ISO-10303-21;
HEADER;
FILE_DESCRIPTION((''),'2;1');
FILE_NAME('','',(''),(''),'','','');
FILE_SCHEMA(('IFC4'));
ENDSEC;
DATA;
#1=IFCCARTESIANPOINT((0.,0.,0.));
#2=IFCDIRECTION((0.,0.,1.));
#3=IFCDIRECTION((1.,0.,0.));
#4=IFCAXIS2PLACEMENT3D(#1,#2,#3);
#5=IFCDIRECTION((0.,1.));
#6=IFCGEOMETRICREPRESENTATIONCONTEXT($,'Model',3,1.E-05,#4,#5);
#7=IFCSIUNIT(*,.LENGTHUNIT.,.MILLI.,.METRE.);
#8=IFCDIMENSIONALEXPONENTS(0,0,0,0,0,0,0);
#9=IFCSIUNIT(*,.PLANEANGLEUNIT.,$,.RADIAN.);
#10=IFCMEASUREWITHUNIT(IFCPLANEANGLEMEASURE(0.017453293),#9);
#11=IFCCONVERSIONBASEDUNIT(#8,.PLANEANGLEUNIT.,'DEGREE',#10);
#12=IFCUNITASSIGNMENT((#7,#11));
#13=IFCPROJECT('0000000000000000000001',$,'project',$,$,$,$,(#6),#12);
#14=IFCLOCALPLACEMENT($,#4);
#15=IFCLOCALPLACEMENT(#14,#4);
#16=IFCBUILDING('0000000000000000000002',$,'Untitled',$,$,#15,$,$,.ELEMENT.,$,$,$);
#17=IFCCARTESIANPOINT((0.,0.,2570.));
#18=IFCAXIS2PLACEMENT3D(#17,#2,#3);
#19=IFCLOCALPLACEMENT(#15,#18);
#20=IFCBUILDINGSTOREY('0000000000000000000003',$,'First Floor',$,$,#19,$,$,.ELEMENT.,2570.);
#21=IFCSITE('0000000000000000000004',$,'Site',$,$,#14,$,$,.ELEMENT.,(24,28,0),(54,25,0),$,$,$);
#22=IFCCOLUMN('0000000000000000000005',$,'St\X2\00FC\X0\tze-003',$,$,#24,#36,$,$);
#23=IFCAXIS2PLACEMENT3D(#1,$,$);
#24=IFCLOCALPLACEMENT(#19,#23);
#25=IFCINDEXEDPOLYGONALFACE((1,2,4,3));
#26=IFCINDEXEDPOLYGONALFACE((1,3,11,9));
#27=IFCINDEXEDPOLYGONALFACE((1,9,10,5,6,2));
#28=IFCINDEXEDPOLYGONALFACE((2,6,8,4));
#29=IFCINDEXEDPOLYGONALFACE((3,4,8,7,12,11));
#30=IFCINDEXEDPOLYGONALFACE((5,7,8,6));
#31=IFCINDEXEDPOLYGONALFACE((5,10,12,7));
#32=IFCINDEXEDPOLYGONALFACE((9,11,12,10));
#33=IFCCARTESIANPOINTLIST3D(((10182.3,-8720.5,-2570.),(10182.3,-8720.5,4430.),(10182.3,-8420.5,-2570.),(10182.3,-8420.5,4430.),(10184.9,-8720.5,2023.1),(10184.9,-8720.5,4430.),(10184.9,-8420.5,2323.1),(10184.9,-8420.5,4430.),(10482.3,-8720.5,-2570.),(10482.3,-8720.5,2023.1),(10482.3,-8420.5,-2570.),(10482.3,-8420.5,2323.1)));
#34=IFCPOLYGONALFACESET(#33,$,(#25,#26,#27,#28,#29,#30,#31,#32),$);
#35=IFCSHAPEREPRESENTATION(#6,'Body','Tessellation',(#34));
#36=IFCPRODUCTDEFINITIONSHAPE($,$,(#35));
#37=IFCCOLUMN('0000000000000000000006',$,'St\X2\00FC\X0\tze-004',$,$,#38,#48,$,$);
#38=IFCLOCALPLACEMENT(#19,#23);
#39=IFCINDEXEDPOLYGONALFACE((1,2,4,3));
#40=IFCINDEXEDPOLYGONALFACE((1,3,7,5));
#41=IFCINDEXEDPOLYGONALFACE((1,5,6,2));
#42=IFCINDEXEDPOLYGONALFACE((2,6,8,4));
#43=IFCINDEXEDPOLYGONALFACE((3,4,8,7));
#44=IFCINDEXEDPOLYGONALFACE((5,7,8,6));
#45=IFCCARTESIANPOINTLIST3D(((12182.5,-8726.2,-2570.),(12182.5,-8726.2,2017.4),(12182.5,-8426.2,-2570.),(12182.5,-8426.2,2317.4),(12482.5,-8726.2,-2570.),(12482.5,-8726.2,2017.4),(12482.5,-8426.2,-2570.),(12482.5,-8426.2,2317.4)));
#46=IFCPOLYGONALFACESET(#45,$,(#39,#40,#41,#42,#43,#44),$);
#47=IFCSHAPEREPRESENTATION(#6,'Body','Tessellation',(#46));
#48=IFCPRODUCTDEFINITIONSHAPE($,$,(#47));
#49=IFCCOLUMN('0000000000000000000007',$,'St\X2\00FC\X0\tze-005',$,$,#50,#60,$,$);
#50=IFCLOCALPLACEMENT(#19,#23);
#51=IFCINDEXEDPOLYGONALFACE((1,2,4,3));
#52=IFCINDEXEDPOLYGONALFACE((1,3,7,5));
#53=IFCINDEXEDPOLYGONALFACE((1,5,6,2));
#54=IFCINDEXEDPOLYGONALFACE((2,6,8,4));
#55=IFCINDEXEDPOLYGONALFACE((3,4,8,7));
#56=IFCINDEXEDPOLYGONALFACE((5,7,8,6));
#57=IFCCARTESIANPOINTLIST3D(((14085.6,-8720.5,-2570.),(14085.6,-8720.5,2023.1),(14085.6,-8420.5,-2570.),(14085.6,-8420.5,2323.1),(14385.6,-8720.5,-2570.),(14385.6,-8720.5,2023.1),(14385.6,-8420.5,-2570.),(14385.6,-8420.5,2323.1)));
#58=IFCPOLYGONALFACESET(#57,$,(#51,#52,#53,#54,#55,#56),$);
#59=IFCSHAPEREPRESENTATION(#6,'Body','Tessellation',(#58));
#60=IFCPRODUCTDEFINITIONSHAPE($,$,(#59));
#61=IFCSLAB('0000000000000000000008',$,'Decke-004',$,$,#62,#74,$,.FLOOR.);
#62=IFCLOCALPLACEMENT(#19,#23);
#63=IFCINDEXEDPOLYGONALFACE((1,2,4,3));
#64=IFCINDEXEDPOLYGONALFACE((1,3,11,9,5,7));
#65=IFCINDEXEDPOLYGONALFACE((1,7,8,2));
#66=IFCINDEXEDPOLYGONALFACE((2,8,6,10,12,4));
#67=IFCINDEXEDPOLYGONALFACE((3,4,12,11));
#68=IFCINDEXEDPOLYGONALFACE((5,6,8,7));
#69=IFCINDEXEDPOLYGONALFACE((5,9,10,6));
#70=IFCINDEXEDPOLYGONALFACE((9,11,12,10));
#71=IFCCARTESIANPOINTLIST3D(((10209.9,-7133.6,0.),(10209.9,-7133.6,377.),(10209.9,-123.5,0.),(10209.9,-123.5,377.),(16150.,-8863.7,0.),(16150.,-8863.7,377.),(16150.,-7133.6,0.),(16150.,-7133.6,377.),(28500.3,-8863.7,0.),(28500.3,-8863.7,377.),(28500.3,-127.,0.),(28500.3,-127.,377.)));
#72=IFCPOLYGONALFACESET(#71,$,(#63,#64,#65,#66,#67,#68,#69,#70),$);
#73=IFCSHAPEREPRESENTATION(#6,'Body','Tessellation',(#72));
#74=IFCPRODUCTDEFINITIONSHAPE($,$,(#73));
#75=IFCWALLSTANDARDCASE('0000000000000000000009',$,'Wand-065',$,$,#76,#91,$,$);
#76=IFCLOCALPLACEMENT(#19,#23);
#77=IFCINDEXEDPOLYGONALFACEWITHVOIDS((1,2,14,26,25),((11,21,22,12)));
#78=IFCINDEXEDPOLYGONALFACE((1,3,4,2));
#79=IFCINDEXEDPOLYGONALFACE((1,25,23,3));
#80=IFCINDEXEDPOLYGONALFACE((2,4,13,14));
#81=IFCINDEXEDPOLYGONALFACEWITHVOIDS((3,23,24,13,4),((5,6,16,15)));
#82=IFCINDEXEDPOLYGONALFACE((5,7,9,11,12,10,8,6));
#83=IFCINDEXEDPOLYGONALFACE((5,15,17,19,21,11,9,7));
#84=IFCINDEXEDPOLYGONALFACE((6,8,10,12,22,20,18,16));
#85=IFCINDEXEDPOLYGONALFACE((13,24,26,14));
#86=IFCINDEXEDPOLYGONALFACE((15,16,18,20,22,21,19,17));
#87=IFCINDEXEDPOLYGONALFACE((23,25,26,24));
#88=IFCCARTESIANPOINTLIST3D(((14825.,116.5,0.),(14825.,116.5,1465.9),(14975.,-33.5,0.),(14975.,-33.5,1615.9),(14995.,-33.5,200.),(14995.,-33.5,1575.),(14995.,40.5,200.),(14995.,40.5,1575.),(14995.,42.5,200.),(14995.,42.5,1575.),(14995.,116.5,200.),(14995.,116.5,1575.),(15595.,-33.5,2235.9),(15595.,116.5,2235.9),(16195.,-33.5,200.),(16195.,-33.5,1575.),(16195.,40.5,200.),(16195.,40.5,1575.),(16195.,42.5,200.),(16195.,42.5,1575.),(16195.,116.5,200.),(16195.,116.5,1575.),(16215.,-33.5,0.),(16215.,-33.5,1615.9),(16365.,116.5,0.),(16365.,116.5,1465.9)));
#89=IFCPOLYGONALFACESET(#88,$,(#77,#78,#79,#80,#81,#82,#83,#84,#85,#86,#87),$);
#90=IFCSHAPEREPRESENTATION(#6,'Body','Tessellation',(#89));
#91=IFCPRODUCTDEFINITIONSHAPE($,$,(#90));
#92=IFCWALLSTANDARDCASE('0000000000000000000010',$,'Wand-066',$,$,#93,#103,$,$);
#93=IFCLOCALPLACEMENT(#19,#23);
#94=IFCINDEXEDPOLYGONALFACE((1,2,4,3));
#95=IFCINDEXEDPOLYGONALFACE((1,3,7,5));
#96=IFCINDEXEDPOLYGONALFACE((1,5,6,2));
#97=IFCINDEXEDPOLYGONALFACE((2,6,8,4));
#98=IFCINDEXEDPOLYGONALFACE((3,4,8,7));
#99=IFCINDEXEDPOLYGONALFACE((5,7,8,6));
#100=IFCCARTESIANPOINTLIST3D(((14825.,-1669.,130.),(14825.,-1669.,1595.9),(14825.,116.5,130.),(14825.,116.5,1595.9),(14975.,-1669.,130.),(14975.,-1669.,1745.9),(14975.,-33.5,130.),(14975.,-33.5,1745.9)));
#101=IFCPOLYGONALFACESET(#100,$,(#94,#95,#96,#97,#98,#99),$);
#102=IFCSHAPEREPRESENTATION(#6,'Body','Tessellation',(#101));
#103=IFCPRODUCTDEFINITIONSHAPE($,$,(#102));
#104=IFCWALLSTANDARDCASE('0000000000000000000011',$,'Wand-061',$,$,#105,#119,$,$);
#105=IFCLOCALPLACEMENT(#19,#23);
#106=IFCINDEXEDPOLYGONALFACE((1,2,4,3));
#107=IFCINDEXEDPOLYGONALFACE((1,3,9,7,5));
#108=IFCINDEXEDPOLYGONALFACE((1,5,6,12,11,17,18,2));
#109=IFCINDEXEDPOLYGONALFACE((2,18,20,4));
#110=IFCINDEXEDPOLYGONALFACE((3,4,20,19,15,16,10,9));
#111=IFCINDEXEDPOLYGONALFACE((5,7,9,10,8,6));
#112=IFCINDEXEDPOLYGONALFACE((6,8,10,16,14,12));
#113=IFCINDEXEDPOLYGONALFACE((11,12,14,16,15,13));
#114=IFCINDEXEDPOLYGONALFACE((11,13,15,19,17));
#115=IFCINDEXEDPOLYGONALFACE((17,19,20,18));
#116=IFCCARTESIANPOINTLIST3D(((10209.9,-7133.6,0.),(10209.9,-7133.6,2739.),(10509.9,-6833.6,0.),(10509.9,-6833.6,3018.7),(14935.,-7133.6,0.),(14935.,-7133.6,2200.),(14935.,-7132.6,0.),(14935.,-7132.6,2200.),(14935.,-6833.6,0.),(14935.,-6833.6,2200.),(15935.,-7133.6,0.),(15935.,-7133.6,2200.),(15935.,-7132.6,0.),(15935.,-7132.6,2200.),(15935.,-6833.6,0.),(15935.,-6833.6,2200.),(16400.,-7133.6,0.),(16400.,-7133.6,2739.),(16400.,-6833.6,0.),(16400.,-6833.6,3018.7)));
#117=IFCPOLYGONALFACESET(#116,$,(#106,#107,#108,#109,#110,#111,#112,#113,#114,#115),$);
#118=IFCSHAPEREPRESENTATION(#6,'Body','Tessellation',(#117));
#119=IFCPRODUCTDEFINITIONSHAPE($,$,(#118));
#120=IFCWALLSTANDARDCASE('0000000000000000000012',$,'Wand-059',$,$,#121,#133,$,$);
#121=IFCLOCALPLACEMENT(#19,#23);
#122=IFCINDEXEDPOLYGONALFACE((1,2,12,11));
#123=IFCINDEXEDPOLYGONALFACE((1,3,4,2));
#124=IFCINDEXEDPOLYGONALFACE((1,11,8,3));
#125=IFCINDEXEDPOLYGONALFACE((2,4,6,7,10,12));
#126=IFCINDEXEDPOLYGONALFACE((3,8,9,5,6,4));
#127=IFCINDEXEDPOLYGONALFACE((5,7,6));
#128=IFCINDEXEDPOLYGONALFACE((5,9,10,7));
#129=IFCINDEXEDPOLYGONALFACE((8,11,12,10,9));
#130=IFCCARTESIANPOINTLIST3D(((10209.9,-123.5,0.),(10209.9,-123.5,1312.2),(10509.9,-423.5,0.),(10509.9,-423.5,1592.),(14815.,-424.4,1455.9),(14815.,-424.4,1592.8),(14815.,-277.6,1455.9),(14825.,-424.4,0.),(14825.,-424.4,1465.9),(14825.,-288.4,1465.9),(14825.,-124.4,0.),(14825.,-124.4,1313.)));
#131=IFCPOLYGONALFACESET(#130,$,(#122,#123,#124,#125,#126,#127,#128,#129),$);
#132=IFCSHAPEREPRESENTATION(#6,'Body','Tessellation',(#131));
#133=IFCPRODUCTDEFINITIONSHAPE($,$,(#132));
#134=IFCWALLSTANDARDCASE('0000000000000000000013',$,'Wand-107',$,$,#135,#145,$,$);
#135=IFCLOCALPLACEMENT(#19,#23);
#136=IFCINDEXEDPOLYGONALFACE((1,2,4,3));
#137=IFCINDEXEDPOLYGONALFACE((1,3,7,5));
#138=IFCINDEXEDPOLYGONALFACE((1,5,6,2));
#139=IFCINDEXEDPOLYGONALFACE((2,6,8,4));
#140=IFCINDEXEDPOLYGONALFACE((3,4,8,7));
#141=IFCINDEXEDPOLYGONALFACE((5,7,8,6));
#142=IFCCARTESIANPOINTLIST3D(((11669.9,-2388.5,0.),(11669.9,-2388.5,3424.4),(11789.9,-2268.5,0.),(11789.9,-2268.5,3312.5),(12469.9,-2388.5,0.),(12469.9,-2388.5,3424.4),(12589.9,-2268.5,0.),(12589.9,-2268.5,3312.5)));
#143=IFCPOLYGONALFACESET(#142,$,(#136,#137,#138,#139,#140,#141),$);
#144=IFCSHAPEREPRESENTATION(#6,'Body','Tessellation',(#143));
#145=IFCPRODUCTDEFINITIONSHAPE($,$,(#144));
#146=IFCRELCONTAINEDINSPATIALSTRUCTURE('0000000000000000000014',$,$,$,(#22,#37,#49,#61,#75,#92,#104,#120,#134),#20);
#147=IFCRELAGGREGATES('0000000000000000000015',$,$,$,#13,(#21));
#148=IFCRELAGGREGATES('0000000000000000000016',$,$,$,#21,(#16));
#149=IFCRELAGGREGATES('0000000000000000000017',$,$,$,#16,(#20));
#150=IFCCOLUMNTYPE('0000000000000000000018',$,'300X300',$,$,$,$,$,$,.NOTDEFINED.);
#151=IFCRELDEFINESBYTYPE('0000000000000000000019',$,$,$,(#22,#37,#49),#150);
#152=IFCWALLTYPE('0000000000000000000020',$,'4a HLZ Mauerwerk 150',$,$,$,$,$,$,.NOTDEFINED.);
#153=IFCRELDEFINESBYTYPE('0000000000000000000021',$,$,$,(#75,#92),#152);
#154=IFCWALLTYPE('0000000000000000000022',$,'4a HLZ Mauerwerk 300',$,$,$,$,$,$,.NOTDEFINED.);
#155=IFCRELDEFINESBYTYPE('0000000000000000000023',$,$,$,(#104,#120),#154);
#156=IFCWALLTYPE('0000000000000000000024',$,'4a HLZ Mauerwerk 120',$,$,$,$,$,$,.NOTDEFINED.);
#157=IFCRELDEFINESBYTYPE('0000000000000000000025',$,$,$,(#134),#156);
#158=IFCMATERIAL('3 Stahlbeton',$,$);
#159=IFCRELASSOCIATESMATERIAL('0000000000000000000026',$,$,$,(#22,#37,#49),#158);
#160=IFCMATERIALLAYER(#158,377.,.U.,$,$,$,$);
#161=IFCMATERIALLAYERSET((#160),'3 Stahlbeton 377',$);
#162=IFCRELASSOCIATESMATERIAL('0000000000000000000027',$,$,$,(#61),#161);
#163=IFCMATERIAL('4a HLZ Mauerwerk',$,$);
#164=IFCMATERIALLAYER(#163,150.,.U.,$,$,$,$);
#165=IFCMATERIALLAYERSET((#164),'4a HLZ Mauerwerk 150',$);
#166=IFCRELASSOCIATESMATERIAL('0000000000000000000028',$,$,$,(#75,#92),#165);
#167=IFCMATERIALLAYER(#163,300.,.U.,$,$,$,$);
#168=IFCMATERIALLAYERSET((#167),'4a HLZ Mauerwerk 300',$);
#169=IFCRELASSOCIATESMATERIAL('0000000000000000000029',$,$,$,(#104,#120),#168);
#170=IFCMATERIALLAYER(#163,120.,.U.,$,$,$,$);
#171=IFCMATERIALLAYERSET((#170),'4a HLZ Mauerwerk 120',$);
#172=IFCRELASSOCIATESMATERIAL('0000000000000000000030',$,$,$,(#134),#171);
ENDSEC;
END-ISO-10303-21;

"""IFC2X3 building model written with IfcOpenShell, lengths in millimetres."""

from ifc_helpers import new_model, entity, si_unit, converted_unit, direction, frame, origin_with_axes, origin_2d_with_axis, place, context, project, spatial, polyline, rectangle, outline, extrude, clip, halfspace, bounded_halfspace, material, layer, layer_set, layer_usage, type_object, element, save


model = new_model("IFC2X3")

# Units and contexts
model_context = context("Model", 3, precision=1e-05, world=origin_with_axes(), true_north=direction((0.0, 1.0)))
ifc_project = project(units=[si_unit("LENGTHUNIT", "METRE", prefix="MILLI"), converted_unit("PLANEANGLEUNIT", "DEGREE", entity("IfcPlaneAngleMeasure", 0.017453293), si_unit("PLANEANGLEUNIT", "RADIAN"), dimensions=[0, 0, 0, 0, 0, 0, 0])], contexts=[model_context])

# Site, building, storey
site_placement = place(None, origin_with_axes())
site = spatial("IfcSite", under=ifc_project, at=site_placement, Name="Site", CompositionType="ELEMENT", RefLatitude=(24, 28, 0), RefLongitude=(54, 25, 0))
building_placement = place(site_placement, origin_with_axes())
building = spatial("IfcBuilding", under=site, at=building_placement, Name="Untitled", CompositionType="ELEMENT")
storey_placement = place(building_placement, frame((0.0, 0.0, 2570.0), z_axis=(0.0, 0.0, 1.0), x_axis=(1.0, 0.0, 0.0)))
storey = spatial("IfcBuildingStorey", under=building, at=storey_placement, Name="First Floor", CompositionType="ELEMENT", Elevation=2570.0)

# Columns
ifc_material_1 = material(Name="3 Stahlbeton")
column_type = type_object("IfcColumnType", Name="300X300", PredefinedType="NOTDEFINED")
column_1_placement = place(storey_placement, frame((10332.3, -8570.5, -2570.0), z_axis=(0.0, 0.0, 1.0), x_axis=(1.0, 0.0, 0.0)))
element("IfcColumn", 1, at=column_1_placement, inside=storey, type_object=column_type, material=ifc_material_1, Name="Stütze-003", context=model_context, shape_type="Clipping", body=[
    clip(extrude(rectangle(XDim=300.0, YDim=300.0, at=origin_2d_with_axis()), origin_with_axes(), (0.0, 0.0, 1.0), 7000.0), bounded_halfspace(frame((0.0, -2371.6, 2371.6), z_axis=(0.0, 0.707107, -0.707107), x_axis=(0.0, -0.707107, -0.707107)), True, origin_with_axes(), polyline([(-147.5, -150.0), (150.0, -150.0), (150.0, 150.0), (-147.5, 150.0), (-147.5, -150.0)]))),
])
column_2_placement = place(storey_placement, frame((12332.5, -8576.2, -2570.0), z_axis=(0.0, 0.0, 1.0), x_axis=(1.0, 0.0, 0.0)))
element("IfcColumn", 2, at=column_2_placement, inside=storey, type_object=column_type, material=ifc_material_1, Name="Stütze-004", context=model_context, shape_type="Clipping", body=[
    clip(extrude(rectangle(XDim=300.0, YDim=300.0, at=origin_2d_with_axis()), origin_with_axes(), (0.0, 0.0, 1.0), 7000.0), halfspace(frame((0.0, -2368.7, 2368.7), z_axis=(0.0, 0.707107, -0.707107), x_axis=(0.0, -0.707107, -0.707107)), True)),
])
column_3_placement = place(storey_placement, frame((14235.6, -8570.5, -2570.0), z_axis=(0.0, 0.0, 1.0), x_axis=(1.0, 0.0, 0.0)))
element("IfcColumn", 3, at=column_3_placement, inside=storey, type_object=column_type, material=ifc_material_1, Name="Stütze-005", context=model_context, shape_type="Clipping", body=[
    clip(extrude(rectangle(XDim=300.0, YDim=300.0, at=origin_2d_with_axis()), origin_with_axes(), (0.0, 0.0, 1.0), 7000.0), halfspace(frame((0.0, -2371.6, 2371.6), z_axis=(0.0, 0.707107, -0.707107), x_axis=(0.0, -0.707107, -0.707107)), True)),
])

# Slab
ifc_layer_1 = layer(ifc_material_1, 377.0, ventilated="UNKNOWN")
ifc_layer_set_1 = layer_set([ifc_layer_1], Name="3 Stahlbeton 377")
ifc_layer_usage_1 = layer_usage(ifc_layer_set_1, "AXIS3", "NEGATIVE", 377.0)
slab_placement = place(storey_placement, frame((10209.9, -123.5, 0.0), z_axis=(0.0, 0.0, 1.0), x_axis=(1.0, 0.0, 0.0)))
element("IfcSlab", 4, at=slab_placement, inside=storey, material=ifc_layer_usage_1, Name="Decke-004", PredefinedType="FLOOR", context=model_context, shape_type="SweptSolid", body=[
    extrude(outline(polyline([(0.0, 0.0), (0.0, -7010.2), (5940.1, -7010.2), (5940.1, -8740.2), (18290.4, -8740.2), (18290.4, -3.5), (0.0, 0.0)])), origin_with_axes(), (0.0, 0.0, 1.0), 377.0),
])

# Wall, opening
ifc_material_2 = material(Name="4a HLZ Mauerwerk")
ifc_layer_2 = layer(ifc_material_2, 150.0, ventilated="UNKNOWN")
ifc_layer_set_2 = layer_set([ifc_layer_2], Name="4a HLZ Mauerwerk 150")
ifc_layer_usage_2 = layer_usage(ifc_layer_set_2, "AXIS2", "NEGATIVE", 0.0)
wall_type_1 = type_object("IfcWallType", Name="4a HLZ Mauerwerk 150", PredefinedType="NOTDEFINED")
wall_1_placement = place(storey_placement, frame((14825.0, 116.5, 0.0), z_axis=(0.0, 0.0, 1.0), x_axis=(1.0, 0.0, 0.0)))
wall_1 = element("IfcWallStandardCase", 5, at=wall_1_placement, inside=storey, type_object=wall_type_1, material=ifc_layer_usage_2, Name="Wand-065", context=model_context, shape_type="Clipping", body=[
    clip(clip(extrude(outline(polyline([(150.0, -150.0), (1390.0, -150.0), (1540.0, 0.0), (0.0, 0.0), (150.0, -150.0)])), origin_with_axes(), (0.0, 0.0, 1.0), 5316.0), bounded_halfspace(frame((1503.0, 0.0, 1503.0), z_axis=(-0.707107, 0.0, -0.707107), x_axis=(0.707107, 0.0, -0.707107)), True, origin_with_axes(), polyline([(770.0, -150.0), (1540.0, -150.0), (1540.0, 0.0), (770.0, 0.0), (770.0, -150.0)]))), bounded_halfspace(frame((-733.0, 0.0, 733.0), z_axis=(0.707107, 0.0, -0.707107), x_axis=(0.707107, 0.0, 0.707107)), True, origin_with_axes(), polyline([(0.0, -150.0), (770.0, -150.0), (770.0, 0.0), (0.0, 0.0), (0.0, -150.0)]))),
])
opening_1_placement = place(wall_1_placement, frame((770.0, 0.0, 200.0), z_axis=(0.0, 0.0, 1.0), x_axis=(1.0, 0.0, 0.0)))
element("IfcOpeningElement", 6, at=opening_1_placement, cuts=wall_1, context=model_context, shape_type="SweptSolid", body=[
    extrude(rectangle(XDim=1200.0, YDim=1375.0, at=origin_2d_with_axis()), frame((0.0, 226.0, 687.5), z_axis=(0.0, -1.0, 0.0), x_axis=(1.0, 0.0, 0.0)), (0.0, 0.0, 1.0), 302.0),
    extrude(rectangle(XDim=1200.0, YDim=1375.0, at=origin_2d_with_axis()), frame((0.0, -376.0, 687.5), z_axis=(0.0, 1.0, 0.0), x_axis=(1.0, 0.0, 0.0)), (0.0, 0.0, 1.0), 302.0),
])

# Wall
ifc_layer_usage_3 = layer_usage(ifc_layer_set_2, "AXIS2", "POSITIVE", 0.0)
wall_2_placement = place(storey_placement, frame((14825.0, 116.5, 130.0), z_axis=(0.0, 0.0, 1.0), x_axis=(0.0, -1.0, 0.0)))
element("IfcWallStandardCase", 7, at=wall_2_placement, inside=storey, type_object=wall_type_1, material=ifc_layer_usage_3, Name="Wand-066", context=model_context, shape_type="Clipping", body=[
    clip(extrude(outline(polyline([(0.0, 0.0), (1785.6, 0.0), (1785.6, 150.0), (150.0, 150.0), (0.0, 0.0)])), origin_with_axes(), (0.0, 0.0, 1.0), 5186.0), halfspace(frame((0.0, -733.0, 733.0), z_axis=(0.0, 0.707107, -0.707107), x_axis=(0.0, -0.707107, -0.707107)), True)),
])

# Shared definitions
ifc_layer_3 = layer(ifc_material_2, 300.0, ventilated="UNKNOWN")
ifc_layer_set_3 = layer_set([ifc_layer_3], Name="4a HLZ Mauerwerk 300")
wall_type_2 = type_object("IfcWallType", Name="4a HLZ Mauerwerk 300", PredefinedType="NOTDEFINED")

# Wall, opening
ifc_layer_usage_4 = layer_usage(ifc_layer_set_3, "AXIS2", "POSITIVE", 0.0)
wall_3_placement = place(storey_placement, frame((10209.9, -7133.6, 0.0), z_axis=(0.0, 0.0, 1.0), x_axis=(1.0, 0.0, 0.0)))
wall_3 = element("IfcWallStandardCase", 8, at=wall_3_placement, inside=storey, type_object=wall_type_2, material=ifc_layer_usage_4, Name="Wand-061", context=model_context, shape_type="Clipping", body=[
    clip(extrude(outline(polyline([(0.0, 0.0), (6190.1, 0.0), (6190.1, 300.0), (300.0, 300.0), (0.0, 0.0)])), origin_with_axes(), (0.0, 0.0, 1.0), 5316.0), bounded_halfspace(frame((0.0, -1366.1, 1465.0), z_axis=(0.0, 0.681998, -0.731354), x_axis=(0.0, -0.731354, -0.681998)), True, origin_with_axes(), polyline([(0.0, 0.0), (6190.1, 0.0), (6190.1, 300.0), (0.0, 300.0), (0.0, 0.0)]))),
])
opening_2_placement = place(wall_3_placement, frame((5225.1, 0.0, 0.0), z_axis=(0.0, 0.0, 1.0), x_axis=(1.0, 0.0, 0.0)))
element("IfcOpeningElement", 9, at=opening_2_placement, cuts=wall_3, context=model_context, shape_type="SweptSolid", body=[
    extrude(rectangle(XDim=1000.0, YDim=2200.0, at=origin_2d_with_axis()), frame((0.0, -601.0, 1100.0), z_axis=(0.0, 1.0, 0.0), x_axis=(1.0, 0.0, 0.0)), (0.0, 0.0, 1.0), 602.0),
    extrude(rectangle(XDim=1000.0, YDim=2200.0, at=origin_2d_with_axis()), frame((0.0, 601.0, 1100.0), z_axis=(0.0, -1.0, 0.0), x_axis=(1.0, 0.0, 0.0)), (0.0, 0.0, 1.0), 602.0),
])

# Walls
ifc_layer_usage_5 = layer_usage(ifc_layer_set_3, "AXIS2", "NEGATIVE", 0.0)
wall_4_placement = place(storey_placement, frame((10209.9, -123.5, 0.0), z_axis=(0.0, 0.0, 1.0), x_axis=(1.0, -0.000191, 0.0)))
element("IfcWallStandardCase", 10, at=wall_4_placement, inside=storey, type_object=wall_type_2, material=ifc_layer_usage_5, Name="Wand-059", context=model_context, shape_type="Clipping", body=[
    clip(clip(clip(clip(extrude(outline(polyline([(300.1, -300.0), (4615.2, -300.0), (4615.1, 0.0), (0.0, 0.0), (300.1, -300.0)])), origin_with_axes(), (0.0, 0.0, 1.0), 5316.0), bounded_halfspace(frame((1574.6, 0.3, -1574.6), z_axis=(0.707107, 0.000135, -0.707107), x_axis=(0.707107, 0.0, 0.707107)), True, origin_with_axes(), polyline([(4605.2, -300.0), (4615.2, -300.0), (4615.2, 0.0), (4605.1, 0.0), (4605.2, -300.0)]))), bounded_halfspace(frame((1574.6, 0.3, -1574.6), z_axis=(0.707107, 0.000135, -0.707107), x_axis=(0.707107, 0.0, 0.707107)), True, origin_with_axes(), polyline([(4605.2, -300.0), (4615.2, -300.0), (4615.2, 0.0), (4605.1, 0.0), (4605.2, -300.0)]))), bounded_halfspace(frame((-0.1, 654.5, 701.9), z_axis=(0.00013, -0.681998, -0.731354), x_axis=(0.0, -0.731354, 0.681998)), True, origin_with_axes(), polyline([(0.0, 0.0), (0.1, -300.0), (4615.2, -300.0), (4615.2, -233.9), (4615.1, 0.0), (0.0, 0.0), (0.0, 0.0)]))), bounded_halfspace(frame((-0.1, 654.5, 701.9), z_axis=(0.00013, -0.681998, -0.731354), x_axis=(0.0, -0.731354, 0.681998)), True, origin_with_axes(), polyline([(0.0, 0.0), (0.1, -300.0), (4615.2, -300.0), (4615.2, -233.9), (4615.1, 0.0), (0.0, 0.0), (0.0, 0.0)]))),
])
ifc_layer_4 = layer(ifc_material_2, 120.0, ventilated="UNKNOWN")
ifc_layer_set_4 = layer_set([ifc_layer_4], Name="4a HLZ Mauerwerk 120")
wall_type_3 = type_object("IfcWallType", Name="4a HLZ Mauerwerk 120", PredefinedType="NOTDEFINED")
ifc_layer_usage_6 = layer_usage(ifc_layer_set_4, "AXIS2", "POSITIVE", 0.0)
wall_5_placement = place(storey_placement, frame((11669.9, -2388.5, 0.0), z_axis=(0.0, 0.0, 1.0), x_axis=(1.0, 0.0, 0.0)))
element("IfcWallStandardCase", 11, at=wall_5_placement, inside=storey, type_object=wall_type_3, material=ifc_layer_usage_6, Name="Wand-107", context=model_context, shape_type="Clipping", body=[
    clip(extrude(outline(polyline([(0.0, 0.0), (800.0, 0.0), (920.0, 120.0), (120.0, 120.0), (0.0, 0.0)])), origin_with_axes(), (0.0, 0.0, 1.0), 5316.0), halfspace(frame((0.0, 1708.0, 1831.6), z_axis=(0.0, -0.681998, -0.731354), x_axis=(0.0, -0.731354, 0.681998)), True)),
])

save(model, "model.ifc")
